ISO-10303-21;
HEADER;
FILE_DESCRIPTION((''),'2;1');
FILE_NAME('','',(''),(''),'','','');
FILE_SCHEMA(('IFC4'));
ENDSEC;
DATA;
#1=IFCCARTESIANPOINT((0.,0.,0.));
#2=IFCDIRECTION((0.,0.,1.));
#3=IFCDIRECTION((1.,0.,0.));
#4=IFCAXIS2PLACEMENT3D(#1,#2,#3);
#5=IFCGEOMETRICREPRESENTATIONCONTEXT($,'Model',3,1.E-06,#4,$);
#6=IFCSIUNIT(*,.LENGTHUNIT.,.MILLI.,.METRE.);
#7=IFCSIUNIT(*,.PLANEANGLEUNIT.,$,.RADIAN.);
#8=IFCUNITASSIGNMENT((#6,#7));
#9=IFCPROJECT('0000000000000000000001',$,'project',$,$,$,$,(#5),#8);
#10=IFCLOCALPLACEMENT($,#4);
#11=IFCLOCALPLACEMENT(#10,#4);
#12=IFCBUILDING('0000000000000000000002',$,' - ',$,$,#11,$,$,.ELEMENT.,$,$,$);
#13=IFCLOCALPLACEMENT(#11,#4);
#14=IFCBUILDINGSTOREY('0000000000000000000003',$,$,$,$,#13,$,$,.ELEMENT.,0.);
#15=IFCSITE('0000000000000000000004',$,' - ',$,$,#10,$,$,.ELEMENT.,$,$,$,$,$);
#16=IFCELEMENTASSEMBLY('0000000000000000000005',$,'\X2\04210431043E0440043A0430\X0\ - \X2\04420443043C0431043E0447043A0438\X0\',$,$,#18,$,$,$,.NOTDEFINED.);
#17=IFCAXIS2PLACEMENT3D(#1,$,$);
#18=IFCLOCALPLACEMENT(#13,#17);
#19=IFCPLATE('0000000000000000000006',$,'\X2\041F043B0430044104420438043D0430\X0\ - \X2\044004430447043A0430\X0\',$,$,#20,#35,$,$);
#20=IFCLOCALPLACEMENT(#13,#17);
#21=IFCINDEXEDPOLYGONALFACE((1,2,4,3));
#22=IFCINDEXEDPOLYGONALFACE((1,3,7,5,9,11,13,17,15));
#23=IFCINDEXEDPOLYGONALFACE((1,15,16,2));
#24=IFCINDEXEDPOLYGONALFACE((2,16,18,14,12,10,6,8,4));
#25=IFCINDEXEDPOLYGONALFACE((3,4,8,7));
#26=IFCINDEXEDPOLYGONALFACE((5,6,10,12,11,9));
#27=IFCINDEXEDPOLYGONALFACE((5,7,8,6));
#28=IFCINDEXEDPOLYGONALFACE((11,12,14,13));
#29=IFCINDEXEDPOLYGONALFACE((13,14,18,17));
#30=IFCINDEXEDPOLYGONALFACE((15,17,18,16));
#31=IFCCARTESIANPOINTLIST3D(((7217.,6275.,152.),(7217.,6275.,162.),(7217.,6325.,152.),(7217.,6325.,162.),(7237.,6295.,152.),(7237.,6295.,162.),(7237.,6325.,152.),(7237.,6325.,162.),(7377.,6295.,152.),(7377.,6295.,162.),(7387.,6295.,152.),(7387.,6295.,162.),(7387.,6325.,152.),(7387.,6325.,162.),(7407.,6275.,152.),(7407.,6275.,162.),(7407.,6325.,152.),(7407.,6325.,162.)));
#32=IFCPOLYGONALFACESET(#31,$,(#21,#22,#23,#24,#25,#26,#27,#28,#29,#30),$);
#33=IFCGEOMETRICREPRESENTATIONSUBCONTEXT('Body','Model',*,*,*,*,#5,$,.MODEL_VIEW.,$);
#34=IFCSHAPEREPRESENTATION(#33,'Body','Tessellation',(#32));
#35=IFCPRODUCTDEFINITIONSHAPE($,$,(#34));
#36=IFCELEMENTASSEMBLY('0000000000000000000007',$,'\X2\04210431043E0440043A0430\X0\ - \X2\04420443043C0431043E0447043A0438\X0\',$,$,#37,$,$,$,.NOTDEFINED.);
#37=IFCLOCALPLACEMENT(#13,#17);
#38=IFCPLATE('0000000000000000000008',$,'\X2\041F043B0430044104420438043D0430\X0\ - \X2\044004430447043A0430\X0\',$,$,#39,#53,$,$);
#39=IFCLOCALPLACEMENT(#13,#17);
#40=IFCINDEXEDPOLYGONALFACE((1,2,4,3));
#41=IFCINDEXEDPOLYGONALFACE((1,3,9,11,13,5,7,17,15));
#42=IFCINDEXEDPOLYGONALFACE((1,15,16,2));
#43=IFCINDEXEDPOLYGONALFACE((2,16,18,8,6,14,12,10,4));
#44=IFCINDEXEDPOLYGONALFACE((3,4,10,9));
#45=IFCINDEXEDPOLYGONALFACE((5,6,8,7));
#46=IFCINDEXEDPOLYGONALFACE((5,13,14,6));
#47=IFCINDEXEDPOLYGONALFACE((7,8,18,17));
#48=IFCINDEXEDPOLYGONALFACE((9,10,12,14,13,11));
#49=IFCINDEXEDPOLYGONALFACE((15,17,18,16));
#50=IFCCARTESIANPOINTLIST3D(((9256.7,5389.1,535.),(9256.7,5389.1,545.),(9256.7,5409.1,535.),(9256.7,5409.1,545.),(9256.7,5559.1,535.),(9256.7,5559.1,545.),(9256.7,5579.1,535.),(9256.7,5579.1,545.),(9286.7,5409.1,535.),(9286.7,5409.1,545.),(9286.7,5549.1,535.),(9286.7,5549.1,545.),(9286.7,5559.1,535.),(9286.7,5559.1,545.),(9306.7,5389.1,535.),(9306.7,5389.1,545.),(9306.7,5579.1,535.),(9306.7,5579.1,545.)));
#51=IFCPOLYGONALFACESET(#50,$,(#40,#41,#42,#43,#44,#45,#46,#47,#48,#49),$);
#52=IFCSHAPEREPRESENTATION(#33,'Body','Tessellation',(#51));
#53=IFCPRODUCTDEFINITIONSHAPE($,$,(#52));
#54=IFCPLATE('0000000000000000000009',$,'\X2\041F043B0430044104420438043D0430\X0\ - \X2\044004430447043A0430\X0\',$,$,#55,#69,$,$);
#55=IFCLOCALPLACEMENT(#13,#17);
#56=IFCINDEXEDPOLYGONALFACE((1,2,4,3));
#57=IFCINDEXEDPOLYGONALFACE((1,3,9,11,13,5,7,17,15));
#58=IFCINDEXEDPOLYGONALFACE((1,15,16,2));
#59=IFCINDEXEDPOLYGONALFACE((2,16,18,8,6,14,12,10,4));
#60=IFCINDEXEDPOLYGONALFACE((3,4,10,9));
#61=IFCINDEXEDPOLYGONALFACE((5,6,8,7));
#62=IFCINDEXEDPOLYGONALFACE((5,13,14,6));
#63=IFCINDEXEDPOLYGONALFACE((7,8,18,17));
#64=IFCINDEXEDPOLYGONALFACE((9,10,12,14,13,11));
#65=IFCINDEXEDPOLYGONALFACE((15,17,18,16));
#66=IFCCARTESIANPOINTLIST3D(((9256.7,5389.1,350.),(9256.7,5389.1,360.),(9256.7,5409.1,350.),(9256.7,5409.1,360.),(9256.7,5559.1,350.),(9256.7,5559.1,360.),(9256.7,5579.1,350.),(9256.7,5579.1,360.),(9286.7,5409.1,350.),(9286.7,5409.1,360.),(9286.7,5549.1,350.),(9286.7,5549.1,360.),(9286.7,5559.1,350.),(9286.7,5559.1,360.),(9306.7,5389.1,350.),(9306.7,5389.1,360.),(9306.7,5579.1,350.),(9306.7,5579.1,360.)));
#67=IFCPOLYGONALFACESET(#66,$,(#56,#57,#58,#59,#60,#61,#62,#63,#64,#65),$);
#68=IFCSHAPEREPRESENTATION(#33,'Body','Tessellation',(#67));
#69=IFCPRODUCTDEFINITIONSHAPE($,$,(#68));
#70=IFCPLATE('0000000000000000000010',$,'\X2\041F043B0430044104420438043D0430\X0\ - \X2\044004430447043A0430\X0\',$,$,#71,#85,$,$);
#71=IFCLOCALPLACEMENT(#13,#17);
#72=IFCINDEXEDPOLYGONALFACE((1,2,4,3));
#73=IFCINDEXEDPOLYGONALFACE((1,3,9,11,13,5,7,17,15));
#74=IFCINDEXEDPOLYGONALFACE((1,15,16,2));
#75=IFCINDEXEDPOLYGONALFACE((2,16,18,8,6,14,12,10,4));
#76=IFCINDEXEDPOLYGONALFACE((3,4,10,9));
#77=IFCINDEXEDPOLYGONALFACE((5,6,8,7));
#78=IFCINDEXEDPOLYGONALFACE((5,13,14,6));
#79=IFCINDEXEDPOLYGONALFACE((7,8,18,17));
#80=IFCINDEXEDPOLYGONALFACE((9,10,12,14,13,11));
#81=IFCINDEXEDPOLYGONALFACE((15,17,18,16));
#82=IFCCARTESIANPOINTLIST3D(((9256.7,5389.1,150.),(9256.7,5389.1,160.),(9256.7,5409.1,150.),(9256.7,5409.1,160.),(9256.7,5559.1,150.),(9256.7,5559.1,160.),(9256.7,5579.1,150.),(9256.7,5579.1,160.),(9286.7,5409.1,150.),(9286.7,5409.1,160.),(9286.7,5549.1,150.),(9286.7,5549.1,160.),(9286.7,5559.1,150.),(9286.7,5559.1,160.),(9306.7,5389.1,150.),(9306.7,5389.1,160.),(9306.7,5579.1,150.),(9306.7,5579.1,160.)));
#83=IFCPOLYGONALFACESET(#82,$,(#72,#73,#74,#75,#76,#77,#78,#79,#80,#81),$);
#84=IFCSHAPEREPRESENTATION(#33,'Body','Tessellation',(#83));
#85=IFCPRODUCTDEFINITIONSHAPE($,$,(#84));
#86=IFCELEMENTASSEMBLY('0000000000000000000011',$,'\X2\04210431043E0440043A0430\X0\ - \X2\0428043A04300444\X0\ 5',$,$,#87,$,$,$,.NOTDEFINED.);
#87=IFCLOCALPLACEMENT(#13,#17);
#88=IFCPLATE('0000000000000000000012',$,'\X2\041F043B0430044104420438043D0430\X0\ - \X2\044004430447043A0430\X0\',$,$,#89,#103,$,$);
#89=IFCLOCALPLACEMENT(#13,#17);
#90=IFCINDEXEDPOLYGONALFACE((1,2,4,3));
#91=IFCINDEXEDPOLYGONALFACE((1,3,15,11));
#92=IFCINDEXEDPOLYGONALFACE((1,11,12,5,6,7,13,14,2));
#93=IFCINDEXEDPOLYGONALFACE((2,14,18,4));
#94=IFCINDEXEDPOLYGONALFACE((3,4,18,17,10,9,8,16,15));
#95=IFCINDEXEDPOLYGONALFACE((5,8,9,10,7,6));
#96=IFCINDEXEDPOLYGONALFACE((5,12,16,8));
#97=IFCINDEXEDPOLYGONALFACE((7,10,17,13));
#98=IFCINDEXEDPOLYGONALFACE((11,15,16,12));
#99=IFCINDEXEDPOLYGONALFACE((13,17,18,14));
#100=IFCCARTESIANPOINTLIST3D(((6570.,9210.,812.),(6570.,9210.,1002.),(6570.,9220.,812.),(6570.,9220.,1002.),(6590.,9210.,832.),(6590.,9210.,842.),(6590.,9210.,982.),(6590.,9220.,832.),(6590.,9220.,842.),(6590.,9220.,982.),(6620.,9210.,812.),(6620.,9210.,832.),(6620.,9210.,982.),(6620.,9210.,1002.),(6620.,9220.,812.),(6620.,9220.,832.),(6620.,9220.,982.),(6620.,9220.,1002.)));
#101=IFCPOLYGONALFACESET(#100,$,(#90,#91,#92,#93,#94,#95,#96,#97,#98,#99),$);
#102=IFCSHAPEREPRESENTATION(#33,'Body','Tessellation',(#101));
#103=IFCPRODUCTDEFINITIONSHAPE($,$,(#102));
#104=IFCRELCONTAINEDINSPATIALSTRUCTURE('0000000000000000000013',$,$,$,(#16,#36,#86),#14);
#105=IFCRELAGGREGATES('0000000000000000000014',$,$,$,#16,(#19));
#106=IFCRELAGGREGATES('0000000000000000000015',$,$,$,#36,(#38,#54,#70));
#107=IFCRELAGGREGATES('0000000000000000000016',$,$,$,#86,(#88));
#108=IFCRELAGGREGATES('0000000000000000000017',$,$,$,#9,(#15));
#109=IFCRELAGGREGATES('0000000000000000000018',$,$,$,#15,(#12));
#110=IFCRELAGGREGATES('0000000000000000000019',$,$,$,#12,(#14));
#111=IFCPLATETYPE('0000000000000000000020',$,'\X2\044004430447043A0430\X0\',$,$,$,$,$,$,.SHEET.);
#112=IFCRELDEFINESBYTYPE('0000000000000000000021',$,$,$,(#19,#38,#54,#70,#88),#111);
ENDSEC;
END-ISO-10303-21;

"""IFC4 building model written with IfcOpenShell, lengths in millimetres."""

from ifc_helpers import new_model, si_unit, frame, origin_with_axes, place, context, subcontext, project, spatial, line, indexed_curve, outline, extrude, source, transform, mapped, type_object, element, aggregate, save


model = new_model("IFC4")

# Units and contexts
model_context = context("Model", 3, precision=1e-06, world=origin_with_axes())
body_context = subcontext(model_context, "Body", "Model", "MODEL_VIEW")
ifc_project = project(units=[si_unit("LENGTHUNIT", "METRE", prefix="MILLI"), si_unit("PLANEANGLEUNIT", "RADIAN")], contexts=[model_context])

# Site, building, storey
site_placement = place(None, origin_with_axes())
site = spatial("IfcSite", under=ifc_project, at=site_placement, Name=" - ", CompositionType="ELEMENT")
building_placement = place(site_placement, origin_with_axes())
building = spatial("IfcBuilding", under=site, at=building_placement, Name=" - ", CompositionType="ELEMENT")
storey_placement = place(building_placement, origin_with_axes())
storey = spatial("IfcBuildingStorey", under=building, at=storey_placement, CompositionType="ELEMENT", Elevation=0.0)

# Element assemblies, plates
plate_type = type_object("IfcPlateType", Name="ручка", PredefinedType="SHEET")
shared_shape_1 = source(origin_with_axes(), body_context, "Body", "SweptSolid", [
    extrude(outline(indexed_curve([(-95.0, -25.0), (-75.0, -25.0), (-75.0, 5.0), (-65.0, 5.0), (75.0, 5.0), (75.0, -25.0), (95.0, -25.0), (95.0, 25.0), (-95.0, 25.0)], segments=[line(1, 2), line(2, 3), line(3, 4), line(4, 5), line(5, 6), line(6, 7), line(7, 8), line(8, 9), line(9, 1)])), origin_with_axes(), (0.0, 0.0, 1.0), 10.0),
])
assembly_1_placement = place(storey_placement, frame((7112.0, 6325.0, 2.0), z_axis=(0.0, 0.0, 1.0), x_axis=(1.0, 0.0, 0.0)))
assembly_1 = element("IfcElementAssembly", 1, at=assembly_1_placement, inside=storey, Name="Сборка - тумбочки", PredefinedType="NOTDEFINED")
plate_1_placement = place(assembly_1_placement, frame((200.0, -25.0, 150.0), z_axis=(0.0, 0.0, 1.0), x_axis=(-1.0, 0.0, 0.0)))
plate_1 = element("IfcPlate", 2, at=plate_1_placement, type_object=plate_type, Name="Пластина - ручка", context=body_context, shape_type="MappedRepresentation", body=[
    mapped(shared_shape_1, transform((0.0, 0.0, 0.0), x_axis=(1.0, 0.0, 0.0), y_axis=(0.0, 1.0, 0.0), z_axis=(0.0, 0.0, 1.0), scale=1.0)),
])
aggregate(assembly_1, [plate_1])
assembly_2_placement = place(storey_placement, frame((9256.7, 5284.1, 0.0), z_axis=(0.0, 0.0, 1.0), x_axis=(0.0, 1.0, 0.0)))
assembly_2 = element("IfcElementAssembly", 3, at=assembly_2_placement, inside=storey, Name="Сборка - тумбочки", PredefinedType="NOTDEFINED")
plate_2_placement = place(assembly_2_placement, frame((200.0, -25.0, 535.0), z_axis=(0.0, 0.0, 1.0), x_axis=(-1.0, 0.0, 0.0)))
plate_2 = element("IfcPlate", 4, at=plate_2_placement, type_object=plate_type, Name="Пластина - ручка", context=body_context, shape_type="MappedRepresentation", body=[
    mapped(shared_shape_1, transform((0.0, 0.0, 0.0), x_axis=(1.0, 0.0, 0.0), y_axis=(0.0, 1.0, 0.0), z_axis=(0.0, 0.0, 1.0), scale=1.0)),
])
plate_3_placement = place(assembly_2_placement, frame((200.0, -25.0, 350.0), z_axis=(0.0, 0.0, 1.0), x_axis=(-1.0, 0.0, 0.0)))
plate_3 = element("IfcPlate", 5, at=plate_3_placement, type_object=plate_type, Name="Пластина - ручка", context=body_context, shape_type="MappedRepresentation", body=[
    mapped(shared_shape_1, transform((0.0, 0.0, 0.0), x_axis=(1.0, 0.0, 0.0), y_axis=(0.0, 1.0, 0.0), z_axis=(0.0, 0.0, 1.0), scale=1.0)),
])
plate_4_placement = place(assembly_2_placement, frame((200.0, -25.0, 150.0), z_axis=(0.0, 0.0, 1.0), x_axis=(-1.0, 0.0, 0.0)))
plate_4 = element("IfcPlate", 6, at=plate_4_placement, type_object=plate_type, Name="Пластина - ручка", context=body_context, shape_type="MappedRepresentation", body=[
    mapped(shared_shape_1, transform((0.0, 0.0, 0.0), x_axis=(1.0, 0.0, 0.0), y_axis=(0.0, 1.0, 0.0), z_axis=(0.0, 0.0, 1.0), scale=1.0)),
])
aggregate(assembly_2, [plate_2, plate_3, plate_4])

# Element assembly, plate
assembly_3_placement = place(storey_placement, frame((6620.0, 9650.0, 2.0), z_axis=(0.0, 0.0, 1.0), x_axis=(0.0, -1.0, 0.0)))
assembly_3 = element("IfcElementAssembly", 7, at=assembly_3_placement, inside=storey, Name="Сборка - Шкаф 5", PredefinedType="NOTDEFINED")
shared_shape_2 = source(origin_with_axes(), body_context, "Body", "SweptSolid", [
    extrude(outline(indexed_curve([(-95.0, -25.0), (-75.0, -25.0), (-75.0, 5.0), (-65.0, 5.0), (75.0, 5.0), (75.0, -25.0), (95.0, -25.0), (95.0, 25.0), (-95.0, 25.0)], segments=[line(1, 2), line(2, 3), line(3, 4), line(4, 5), line(5, 6), line(6, 7), line(7, 8), line(8, 9), line(9, 1)])), origin_with_axes(), (0.0, 0.0, 1.0), 10.0),
])
plate_5_placement = place(assembly_3_placement, frame((430.0, -25.0, 905.0), z_axis=(1.0, 0.0, 0.0), x_axis=(0.0, 0.0, 1.0)))
plate_5 = element("IfcPlate", 8, at=plate_5_placement, type_object=plate_type, Name="Пластина - ручка", context=body_context, shape_type="MappedRepresentation", body=[
    mapped(shared_shape_2, transform((0.0, 0.0, 0.0), x_axis=(1.0, 0.0, 0.0), y_axis=(0.0, 1.0, 0.0), z_axis=(0.0, 0.0, 1.0), scale=1.0)),
])
aggregate(assembly_3, [plate_5])

save(model, "model.ifc")
